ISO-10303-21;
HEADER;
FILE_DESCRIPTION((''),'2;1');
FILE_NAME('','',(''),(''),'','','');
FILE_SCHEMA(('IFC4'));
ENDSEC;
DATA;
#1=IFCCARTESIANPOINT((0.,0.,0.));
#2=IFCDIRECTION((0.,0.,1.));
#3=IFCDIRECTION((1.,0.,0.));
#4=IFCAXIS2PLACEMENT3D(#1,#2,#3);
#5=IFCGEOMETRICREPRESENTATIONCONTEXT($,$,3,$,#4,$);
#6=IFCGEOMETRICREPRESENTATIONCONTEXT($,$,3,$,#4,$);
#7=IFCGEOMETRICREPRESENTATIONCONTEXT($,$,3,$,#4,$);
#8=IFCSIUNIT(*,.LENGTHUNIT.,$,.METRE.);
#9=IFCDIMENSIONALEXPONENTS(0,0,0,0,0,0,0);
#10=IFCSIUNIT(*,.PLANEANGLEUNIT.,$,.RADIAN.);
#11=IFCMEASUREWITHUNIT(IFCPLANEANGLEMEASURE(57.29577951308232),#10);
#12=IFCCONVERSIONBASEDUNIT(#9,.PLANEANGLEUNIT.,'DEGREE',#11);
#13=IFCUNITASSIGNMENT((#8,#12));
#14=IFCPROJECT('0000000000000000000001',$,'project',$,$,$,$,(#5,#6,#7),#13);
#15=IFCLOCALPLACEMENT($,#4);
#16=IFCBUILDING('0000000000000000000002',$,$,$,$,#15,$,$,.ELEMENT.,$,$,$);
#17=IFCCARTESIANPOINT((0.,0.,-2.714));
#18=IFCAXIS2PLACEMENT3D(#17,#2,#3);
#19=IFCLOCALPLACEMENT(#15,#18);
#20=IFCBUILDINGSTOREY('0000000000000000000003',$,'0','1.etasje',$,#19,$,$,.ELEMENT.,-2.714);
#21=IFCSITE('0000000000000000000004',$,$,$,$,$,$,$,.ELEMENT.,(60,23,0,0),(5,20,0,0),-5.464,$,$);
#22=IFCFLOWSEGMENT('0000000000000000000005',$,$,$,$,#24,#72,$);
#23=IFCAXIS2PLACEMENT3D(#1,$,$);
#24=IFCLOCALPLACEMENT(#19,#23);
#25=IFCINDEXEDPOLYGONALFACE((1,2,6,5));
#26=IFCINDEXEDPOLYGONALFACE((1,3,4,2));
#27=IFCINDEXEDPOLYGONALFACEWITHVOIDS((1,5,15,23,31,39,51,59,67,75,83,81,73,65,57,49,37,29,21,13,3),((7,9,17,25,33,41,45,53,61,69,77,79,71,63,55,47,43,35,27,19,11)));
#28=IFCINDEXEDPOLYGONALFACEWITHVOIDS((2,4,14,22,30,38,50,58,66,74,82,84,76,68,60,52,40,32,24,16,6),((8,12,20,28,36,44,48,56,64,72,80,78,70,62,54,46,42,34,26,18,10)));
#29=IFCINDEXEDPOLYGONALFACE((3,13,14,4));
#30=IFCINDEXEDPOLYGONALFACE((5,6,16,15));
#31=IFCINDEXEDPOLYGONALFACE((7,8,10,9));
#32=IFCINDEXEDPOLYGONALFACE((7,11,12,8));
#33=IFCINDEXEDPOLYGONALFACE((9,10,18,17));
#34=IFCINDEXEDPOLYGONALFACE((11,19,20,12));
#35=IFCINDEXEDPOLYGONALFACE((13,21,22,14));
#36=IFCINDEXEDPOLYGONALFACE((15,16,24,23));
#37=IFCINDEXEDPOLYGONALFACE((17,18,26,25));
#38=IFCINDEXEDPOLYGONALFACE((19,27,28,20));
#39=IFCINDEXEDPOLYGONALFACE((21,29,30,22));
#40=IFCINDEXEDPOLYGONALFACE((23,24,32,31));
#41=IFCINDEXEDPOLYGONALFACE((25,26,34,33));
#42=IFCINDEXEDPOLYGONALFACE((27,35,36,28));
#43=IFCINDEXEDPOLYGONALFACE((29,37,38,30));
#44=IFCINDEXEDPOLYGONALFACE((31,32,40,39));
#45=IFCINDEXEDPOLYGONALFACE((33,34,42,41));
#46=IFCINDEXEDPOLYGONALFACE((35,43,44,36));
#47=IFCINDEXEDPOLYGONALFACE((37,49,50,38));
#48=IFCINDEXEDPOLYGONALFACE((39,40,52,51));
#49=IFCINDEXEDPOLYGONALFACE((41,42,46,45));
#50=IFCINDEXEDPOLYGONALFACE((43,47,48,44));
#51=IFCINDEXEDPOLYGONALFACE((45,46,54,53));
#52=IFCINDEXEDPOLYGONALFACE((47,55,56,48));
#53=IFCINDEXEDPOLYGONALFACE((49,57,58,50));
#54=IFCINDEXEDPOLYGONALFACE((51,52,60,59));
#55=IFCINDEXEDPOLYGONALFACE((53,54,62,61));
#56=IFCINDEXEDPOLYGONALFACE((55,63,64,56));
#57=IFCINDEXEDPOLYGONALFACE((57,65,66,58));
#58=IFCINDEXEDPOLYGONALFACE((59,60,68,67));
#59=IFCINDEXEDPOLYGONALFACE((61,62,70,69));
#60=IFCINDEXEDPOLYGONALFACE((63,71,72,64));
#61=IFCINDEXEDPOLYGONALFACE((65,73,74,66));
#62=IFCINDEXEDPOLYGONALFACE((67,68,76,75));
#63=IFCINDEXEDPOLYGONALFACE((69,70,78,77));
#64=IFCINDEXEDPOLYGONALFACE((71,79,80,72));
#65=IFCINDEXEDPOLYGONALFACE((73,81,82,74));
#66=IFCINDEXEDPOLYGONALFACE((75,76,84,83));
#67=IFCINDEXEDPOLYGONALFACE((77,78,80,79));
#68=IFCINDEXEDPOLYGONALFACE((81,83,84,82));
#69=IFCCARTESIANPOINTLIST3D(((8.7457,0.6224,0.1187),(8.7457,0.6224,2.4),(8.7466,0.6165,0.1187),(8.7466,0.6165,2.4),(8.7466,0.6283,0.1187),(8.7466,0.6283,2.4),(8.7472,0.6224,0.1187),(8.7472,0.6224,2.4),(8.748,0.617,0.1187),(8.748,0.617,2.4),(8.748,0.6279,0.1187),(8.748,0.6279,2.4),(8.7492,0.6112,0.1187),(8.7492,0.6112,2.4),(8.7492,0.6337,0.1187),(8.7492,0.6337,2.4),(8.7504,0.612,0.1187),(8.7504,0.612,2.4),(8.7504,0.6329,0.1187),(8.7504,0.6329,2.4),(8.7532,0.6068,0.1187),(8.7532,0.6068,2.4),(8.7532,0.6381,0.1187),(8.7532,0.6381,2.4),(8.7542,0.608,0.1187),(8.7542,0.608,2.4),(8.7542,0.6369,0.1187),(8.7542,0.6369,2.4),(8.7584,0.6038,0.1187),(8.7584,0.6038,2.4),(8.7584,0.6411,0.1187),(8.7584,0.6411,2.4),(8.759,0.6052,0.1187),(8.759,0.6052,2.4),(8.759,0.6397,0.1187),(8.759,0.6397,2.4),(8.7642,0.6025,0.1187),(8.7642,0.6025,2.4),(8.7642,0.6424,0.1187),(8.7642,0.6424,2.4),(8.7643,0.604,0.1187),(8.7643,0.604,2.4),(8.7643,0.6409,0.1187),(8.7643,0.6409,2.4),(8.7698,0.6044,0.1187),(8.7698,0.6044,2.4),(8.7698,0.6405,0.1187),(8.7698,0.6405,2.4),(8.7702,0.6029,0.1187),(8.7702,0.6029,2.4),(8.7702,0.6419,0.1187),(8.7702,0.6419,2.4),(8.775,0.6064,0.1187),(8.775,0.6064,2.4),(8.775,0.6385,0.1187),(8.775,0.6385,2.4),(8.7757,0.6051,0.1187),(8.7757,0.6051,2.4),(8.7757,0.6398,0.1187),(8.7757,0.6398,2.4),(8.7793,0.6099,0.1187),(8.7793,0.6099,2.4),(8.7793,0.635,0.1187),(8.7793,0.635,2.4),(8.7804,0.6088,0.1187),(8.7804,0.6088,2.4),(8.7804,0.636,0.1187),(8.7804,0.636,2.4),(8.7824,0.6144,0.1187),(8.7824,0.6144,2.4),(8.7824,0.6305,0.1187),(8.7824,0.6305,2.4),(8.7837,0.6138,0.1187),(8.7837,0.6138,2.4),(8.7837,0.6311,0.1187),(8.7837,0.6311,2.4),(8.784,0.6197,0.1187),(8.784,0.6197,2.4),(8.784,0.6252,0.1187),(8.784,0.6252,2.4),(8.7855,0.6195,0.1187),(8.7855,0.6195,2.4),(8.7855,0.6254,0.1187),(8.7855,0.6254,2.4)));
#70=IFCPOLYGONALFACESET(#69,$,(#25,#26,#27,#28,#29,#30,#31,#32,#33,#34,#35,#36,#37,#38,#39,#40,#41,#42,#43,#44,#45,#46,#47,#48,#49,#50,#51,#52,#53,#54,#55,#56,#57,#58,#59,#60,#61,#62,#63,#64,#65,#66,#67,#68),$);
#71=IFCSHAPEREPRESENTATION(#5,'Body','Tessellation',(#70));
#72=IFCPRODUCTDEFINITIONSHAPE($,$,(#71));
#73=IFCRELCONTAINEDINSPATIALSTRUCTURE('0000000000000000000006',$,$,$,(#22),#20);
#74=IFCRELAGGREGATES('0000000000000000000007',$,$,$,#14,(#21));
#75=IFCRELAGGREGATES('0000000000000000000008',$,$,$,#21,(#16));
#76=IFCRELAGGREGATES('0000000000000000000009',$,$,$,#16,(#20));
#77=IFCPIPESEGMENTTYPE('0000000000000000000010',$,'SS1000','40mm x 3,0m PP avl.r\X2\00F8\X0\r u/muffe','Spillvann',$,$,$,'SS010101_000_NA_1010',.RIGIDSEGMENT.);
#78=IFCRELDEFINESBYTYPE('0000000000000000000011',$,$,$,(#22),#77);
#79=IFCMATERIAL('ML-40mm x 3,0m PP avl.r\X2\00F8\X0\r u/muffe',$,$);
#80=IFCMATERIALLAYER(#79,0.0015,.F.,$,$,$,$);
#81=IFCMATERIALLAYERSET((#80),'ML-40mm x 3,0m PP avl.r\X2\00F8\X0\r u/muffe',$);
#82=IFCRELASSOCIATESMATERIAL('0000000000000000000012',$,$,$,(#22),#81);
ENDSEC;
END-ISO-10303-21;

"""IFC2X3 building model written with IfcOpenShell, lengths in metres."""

from ifc_helpers import new_model, entity, si_unit, converted_unit, frame, origin_with_axes, origin_2d_with_axis, place, context, project, spatial, hollow_circle, extrude, material, layer, layer_set, layer_usage, type_object, element, save


model = new_model("IFC2X3")

# Units and contexts
context_of_model_1 = context(None, 3, world=origin_with_axes())
context_of_model_2 = context(None, 3, world=origin_with_axes())
context_of_model_3 = context(None, 3, world=origin_with_axes())
ifc_project = project(units=[si_unit("LENGTHUNIT", "METRE"), converted_unit("PLANEANGLEUNIT", "DEGREE", entity("IfcPlaneAngleMeasure", 57.29577951308232), si_unit("PLANEANGLEUNIT", "RADIAN"), dimensions=[0, 0, 0, 0, 0, 0, 0])], contexts=[context_of_model_1, context_of_model_2, context_of_model_3])

# Site, building, storey
site = spatial("IfcSite", under=ifc_project, CompositionType="ELEMENT", RefLatitude=(60, 23, 0, 0), RefLongitude=(5, 20, 0, 0), RefElevation=-5.464)
building_placement = place(None, origin_with_axes())
building = spatial("IfcBuilding", under=site, at=building_placement, CompositionType="ELEMENT")
storey_placement = place(building_placement, frame((0.0, 0.0, -2.714), z_axis=(0.0, 0.0, 1.0), x_axis=(1.0, 0.0, 0.0)))
storey = spatial("IfcBuildingStorey", under=building, at=storey_placement, Name="0", Description="1.etasje", CompositionType="ELEMENT", Elevation=-2.714)

# Flow segment
ifc_material_1 = material(Name="ML-40mm x 3,0m PP avl.rør u/muffe")
ifc_layer_1 = layer(ifc_material_1, 0.0015, ventilated=False)
ifc_layer_set_1 = layer_set([ifc_layer_1], Name="ML-40mm x 3,0m PP avl.rør u/muffe")
ifc_layer_usage_1 = layer_usage(ifc_layer_set_1, "AXIS2", "POSITIVE", 0.0)
pipe_segment_type_1 = type_object("IfcPipeSegmentType", Name="SS1000", Description="40mm x 3,0m PP avl.rør u/muffe", ApplicableOccurrence="Spillvann", ElementType="SS010101_000_NA_1010", PredefinedType="RIGIDSEGMENT")
flow_segment_1_placement = place(storey_placement, frame((8.7657, 0.6224, 2.4), z_axis=(0.0, 0.0, -1.0), x_axis=(-1.0, 0.0, 0.0)))
element("IfcFlowSegment", 1, at=flow_segment_1_placement, inside=storey, type_object=pipe_segment_type_1, material=ifc_layer_usage_1, context=context_of_model_1, shape_type="SweptSolid", body=[
    extrude(hollow_circle(Radius=0.02, WallThickness=0.0015, at=origin_2d_with_axis()), origin_with_axes(), (0.0, 0.0, 1.0), 2.2813),
])

save(model, "model.ifc")
